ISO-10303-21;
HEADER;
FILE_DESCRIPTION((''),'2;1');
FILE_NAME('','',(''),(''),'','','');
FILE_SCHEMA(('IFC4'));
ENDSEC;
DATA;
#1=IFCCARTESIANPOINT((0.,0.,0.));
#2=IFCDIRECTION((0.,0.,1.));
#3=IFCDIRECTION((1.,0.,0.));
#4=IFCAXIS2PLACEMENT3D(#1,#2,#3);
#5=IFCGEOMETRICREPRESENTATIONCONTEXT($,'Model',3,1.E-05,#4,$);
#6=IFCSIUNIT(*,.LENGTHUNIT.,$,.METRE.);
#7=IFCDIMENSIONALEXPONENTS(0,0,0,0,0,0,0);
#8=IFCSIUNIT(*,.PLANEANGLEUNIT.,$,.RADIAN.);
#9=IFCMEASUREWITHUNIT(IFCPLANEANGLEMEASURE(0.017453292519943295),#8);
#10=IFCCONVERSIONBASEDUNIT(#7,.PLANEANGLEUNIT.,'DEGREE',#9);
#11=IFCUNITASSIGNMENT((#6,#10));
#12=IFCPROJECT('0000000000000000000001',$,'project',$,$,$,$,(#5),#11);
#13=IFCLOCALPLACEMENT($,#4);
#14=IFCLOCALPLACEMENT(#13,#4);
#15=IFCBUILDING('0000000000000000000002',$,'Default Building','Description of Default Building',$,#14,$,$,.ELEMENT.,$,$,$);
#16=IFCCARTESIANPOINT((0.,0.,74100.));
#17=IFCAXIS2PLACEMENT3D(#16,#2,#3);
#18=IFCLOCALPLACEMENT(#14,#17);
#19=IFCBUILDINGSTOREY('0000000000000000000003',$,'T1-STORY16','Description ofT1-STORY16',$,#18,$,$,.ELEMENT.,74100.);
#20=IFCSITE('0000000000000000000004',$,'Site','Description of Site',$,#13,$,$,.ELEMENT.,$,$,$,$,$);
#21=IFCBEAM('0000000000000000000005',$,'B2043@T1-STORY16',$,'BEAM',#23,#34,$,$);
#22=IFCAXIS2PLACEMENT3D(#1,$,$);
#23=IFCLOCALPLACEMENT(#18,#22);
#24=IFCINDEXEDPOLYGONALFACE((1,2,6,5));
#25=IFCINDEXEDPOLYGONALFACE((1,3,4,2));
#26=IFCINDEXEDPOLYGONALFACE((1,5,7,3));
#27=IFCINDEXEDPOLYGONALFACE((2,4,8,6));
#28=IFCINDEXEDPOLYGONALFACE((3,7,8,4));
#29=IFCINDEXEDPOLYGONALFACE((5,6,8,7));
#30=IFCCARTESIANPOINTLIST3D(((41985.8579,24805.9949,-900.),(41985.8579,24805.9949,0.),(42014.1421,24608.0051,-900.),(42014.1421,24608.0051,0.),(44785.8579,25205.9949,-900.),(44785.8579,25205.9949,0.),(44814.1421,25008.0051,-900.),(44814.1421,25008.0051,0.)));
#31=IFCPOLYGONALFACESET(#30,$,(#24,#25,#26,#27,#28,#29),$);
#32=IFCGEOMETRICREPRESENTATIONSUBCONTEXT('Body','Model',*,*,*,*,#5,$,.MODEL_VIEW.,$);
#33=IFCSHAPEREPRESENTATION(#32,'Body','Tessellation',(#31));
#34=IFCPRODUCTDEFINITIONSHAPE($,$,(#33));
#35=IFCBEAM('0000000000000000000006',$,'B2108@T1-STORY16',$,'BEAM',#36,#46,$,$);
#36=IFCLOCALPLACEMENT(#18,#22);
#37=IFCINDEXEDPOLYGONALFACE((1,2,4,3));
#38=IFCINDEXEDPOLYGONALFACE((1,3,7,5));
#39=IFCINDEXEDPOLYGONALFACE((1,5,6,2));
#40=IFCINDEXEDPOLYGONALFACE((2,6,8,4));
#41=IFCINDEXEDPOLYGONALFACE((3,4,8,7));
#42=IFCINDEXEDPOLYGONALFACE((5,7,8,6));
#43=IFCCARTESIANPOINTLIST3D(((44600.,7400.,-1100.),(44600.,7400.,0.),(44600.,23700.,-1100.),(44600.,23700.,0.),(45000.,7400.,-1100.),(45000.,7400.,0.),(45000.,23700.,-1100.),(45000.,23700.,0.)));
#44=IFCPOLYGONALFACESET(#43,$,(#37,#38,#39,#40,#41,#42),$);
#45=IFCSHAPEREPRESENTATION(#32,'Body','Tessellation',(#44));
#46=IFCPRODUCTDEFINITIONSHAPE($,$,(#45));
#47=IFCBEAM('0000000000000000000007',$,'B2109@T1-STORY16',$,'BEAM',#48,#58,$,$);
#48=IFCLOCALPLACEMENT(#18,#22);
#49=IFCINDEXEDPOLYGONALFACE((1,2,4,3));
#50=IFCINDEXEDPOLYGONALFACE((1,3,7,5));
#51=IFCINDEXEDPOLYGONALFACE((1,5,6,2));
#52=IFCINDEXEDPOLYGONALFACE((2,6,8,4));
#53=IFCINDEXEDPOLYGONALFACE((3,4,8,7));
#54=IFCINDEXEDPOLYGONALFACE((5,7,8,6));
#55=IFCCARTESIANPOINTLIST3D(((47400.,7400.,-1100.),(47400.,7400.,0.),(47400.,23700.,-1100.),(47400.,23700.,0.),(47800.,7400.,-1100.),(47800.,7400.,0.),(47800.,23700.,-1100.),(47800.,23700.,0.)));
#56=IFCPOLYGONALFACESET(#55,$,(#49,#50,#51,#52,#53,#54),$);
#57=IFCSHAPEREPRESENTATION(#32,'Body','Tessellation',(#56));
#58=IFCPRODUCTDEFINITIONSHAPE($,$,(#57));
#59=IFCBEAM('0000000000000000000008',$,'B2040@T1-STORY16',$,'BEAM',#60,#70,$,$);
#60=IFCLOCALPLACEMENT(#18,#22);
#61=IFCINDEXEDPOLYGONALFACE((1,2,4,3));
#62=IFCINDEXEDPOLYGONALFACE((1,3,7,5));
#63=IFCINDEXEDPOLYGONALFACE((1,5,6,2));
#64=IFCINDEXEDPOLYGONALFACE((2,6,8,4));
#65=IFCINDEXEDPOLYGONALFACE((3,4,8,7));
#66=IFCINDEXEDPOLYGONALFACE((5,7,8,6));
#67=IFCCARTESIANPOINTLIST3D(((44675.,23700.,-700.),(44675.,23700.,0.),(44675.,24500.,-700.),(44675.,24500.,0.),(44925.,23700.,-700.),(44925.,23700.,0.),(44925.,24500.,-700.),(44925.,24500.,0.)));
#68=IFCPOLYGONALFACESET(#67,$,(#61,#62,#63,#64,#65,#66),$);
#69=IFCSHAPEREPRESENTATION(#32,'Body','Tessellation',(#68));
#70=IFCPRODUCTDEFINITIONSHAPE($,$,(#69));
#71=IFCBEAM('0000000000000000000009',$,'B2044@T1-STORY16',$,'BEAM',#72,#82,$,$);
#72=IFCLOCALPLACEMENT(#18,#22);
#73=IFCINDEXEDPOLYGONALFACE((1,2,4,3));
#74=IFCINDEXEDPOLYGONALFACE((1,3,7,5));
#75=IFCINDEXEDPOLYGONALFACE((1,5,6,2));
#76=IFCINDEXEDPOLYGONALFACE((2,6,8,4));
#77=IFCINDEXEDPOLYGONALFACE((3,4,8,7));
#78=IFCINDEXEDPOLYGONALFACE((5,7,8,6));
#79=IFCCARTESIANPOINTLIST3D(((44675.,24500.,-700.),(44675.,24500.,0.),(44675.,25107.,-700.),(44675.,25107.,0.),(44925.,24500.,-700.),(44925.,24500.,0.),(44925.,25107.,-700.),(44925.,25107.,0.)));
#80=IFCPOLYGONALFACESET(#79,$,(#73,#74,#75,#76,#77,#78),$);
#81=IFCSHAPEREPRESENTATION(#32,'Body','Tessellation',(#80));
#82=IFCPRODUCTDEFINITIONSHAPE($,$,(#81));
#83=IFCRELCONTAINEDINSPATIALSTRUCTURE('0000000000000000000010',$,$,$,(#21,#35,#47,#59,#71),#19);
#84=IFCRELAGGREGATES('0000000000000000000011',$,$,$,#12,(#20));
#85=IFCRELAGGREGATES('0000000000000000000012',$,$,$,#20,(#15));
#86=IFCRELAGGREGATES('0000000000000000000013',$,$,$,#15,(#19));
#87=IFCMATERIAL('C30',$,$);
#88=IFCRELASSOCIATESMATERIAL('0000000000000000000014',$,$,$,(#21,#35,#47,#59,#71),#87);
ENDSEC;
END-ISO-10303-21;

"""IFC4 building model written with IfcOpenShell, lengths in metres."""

from ifc_helpers import new_model, entity, si_unit, converted_unit, frame, origin_with_axes, place, context, subcontext, project, spatial, rectangle, extrude, material, element, save


model = new_model("IFC4")

# Units and contexts
model_context = context("Model", 3, precision=1e-05, world=origin_with_axes())
body_context = subcontext(model_context, "Body", "Model", "MODEL_VIEW")
ifc_project = project(units=[si_unit("LENGTHUNIT", "METRE"), converted_unit("PLANEANGLEUNIT", "DEGREE", entity("IfcPlaneAngleMeasure", 0.017453292519943295), si_unit("PLANEANGLEUNIT", "RADIAN"), dimensions=[0, 0, 0, 0, 0, 0, 0])], contexts=[model_context])

# Site, building, storey
site_placement = place(None, origin_with_axes())
site = spatial("IfcSite", under=ifc_project, at=site_placement, Name="Site", Description="Description of Site", CompositionType="ELEMENT")
building_placement = place(site_placement, origin_with_axes())
building = spatial("IfcBuilding", under=site, at=building_placement, Name="Default Building", Description="Description of Default Building", CompositionType="ELEMENT")
storey_placement = place(building_placement, frame((0.0, 0.0, 74100.0), z_axis=(0.0, 0.0, 1.0), x_axis=(1.0, 0.0, 0.0)))
storey = spatial("IfcBuildingStorey", under=building, at=storey_placement, Name="T1-STORY16", Description="Description ofT1-STORY16", CompositionType="ELEMENT", Elevation=74100.0)

# Beams
ifc_material_1 = material(Name="C30")
beam_1_placement = place(storey_placement, frame((42000.0, 24707.0, -450.0), z_axis=(0.989949, 0.141421, 0.0), x_axis=(-0.141421, 0.989949, 0.0)))
element("IfcBeam", 1, at=beam_1_placement, inside=storey, material=ifc_material_1, Name="B2043@T1-STORY16", ObjectType="BEAM", context=body_context, shape_type="SweptSolid", body=[
    extrude(rectangle(XDim=200.0, YDim=900.0), origin_with_axes(), (0.0, 0.0, 1.0), 2828.4271),
])
for number, where, z_axis, x_axis, name in (
    (2, (44800.0, 7400.0, -550.0), (0.0, 1.0, 0.0), (-1.0, 0.0, 0.0), "B2108@T1-STORY16"),
    (3, (47600.0, 7400.0, -550.0), (0.0, 1.0, 0.0), (-1.0, 0.0, 0.0), "B2109@T1-STORY16"),
):
    element("IfcBeam", number, at=place(storey_placement, frame(where, z_axis=z_axis, x_axis=x_axis)), inside=storey, material=ifc_material_1, Name=name, ObjectType="BEAM", context=body_context, shape_type="SweptSolid", body=[
        extrude(rectangle(XDim=400.0, YDim=1100.0), origin_with_axes(), (0.0, 0.0, 1.0), 16300.0),
    ])
beam_2_placement = place(storey_placement, frame((44800.0, 23700.0, -350.0), z_axis=(0.0, 1.0, 0.0), x_axis=(-1.0, 0.0, 0.0)))
element("IfcBeam", 4, at=beam_2_placement, inside=storey, material=ifc_material_1, Name="B2040@T1-STORY16", ObjectType="BEAM", context=body_context, shape_type="SweptSolid", body=[
    extrude(rectangle(XDim=250.0, YDim=700.0), origin_with_axes(), (0.0, 0.0, 1.0), 800.0),
])
beam_3_placement = place(storey_placement, frame((44800.0, 24500.0, -350.0), z_axis=(0.0, 1.0, 0.0), x_axis=(-1.0, 0.0, 0.0)))
element("IfcBeam", 5, at=beam_3_placement, inside=storey, material=ifc_material_1, Name="B2044@T1-STORY16", ObjectType="BEAM", context=body_context, shape_type="SweptSolid", body=[
    extrude(rectangle(XDim=250.0, YDim=700.0), origin_with_axes(), (0.0, 0.0, 1.0), 607.0),
])

save(model, "model.ifc")
